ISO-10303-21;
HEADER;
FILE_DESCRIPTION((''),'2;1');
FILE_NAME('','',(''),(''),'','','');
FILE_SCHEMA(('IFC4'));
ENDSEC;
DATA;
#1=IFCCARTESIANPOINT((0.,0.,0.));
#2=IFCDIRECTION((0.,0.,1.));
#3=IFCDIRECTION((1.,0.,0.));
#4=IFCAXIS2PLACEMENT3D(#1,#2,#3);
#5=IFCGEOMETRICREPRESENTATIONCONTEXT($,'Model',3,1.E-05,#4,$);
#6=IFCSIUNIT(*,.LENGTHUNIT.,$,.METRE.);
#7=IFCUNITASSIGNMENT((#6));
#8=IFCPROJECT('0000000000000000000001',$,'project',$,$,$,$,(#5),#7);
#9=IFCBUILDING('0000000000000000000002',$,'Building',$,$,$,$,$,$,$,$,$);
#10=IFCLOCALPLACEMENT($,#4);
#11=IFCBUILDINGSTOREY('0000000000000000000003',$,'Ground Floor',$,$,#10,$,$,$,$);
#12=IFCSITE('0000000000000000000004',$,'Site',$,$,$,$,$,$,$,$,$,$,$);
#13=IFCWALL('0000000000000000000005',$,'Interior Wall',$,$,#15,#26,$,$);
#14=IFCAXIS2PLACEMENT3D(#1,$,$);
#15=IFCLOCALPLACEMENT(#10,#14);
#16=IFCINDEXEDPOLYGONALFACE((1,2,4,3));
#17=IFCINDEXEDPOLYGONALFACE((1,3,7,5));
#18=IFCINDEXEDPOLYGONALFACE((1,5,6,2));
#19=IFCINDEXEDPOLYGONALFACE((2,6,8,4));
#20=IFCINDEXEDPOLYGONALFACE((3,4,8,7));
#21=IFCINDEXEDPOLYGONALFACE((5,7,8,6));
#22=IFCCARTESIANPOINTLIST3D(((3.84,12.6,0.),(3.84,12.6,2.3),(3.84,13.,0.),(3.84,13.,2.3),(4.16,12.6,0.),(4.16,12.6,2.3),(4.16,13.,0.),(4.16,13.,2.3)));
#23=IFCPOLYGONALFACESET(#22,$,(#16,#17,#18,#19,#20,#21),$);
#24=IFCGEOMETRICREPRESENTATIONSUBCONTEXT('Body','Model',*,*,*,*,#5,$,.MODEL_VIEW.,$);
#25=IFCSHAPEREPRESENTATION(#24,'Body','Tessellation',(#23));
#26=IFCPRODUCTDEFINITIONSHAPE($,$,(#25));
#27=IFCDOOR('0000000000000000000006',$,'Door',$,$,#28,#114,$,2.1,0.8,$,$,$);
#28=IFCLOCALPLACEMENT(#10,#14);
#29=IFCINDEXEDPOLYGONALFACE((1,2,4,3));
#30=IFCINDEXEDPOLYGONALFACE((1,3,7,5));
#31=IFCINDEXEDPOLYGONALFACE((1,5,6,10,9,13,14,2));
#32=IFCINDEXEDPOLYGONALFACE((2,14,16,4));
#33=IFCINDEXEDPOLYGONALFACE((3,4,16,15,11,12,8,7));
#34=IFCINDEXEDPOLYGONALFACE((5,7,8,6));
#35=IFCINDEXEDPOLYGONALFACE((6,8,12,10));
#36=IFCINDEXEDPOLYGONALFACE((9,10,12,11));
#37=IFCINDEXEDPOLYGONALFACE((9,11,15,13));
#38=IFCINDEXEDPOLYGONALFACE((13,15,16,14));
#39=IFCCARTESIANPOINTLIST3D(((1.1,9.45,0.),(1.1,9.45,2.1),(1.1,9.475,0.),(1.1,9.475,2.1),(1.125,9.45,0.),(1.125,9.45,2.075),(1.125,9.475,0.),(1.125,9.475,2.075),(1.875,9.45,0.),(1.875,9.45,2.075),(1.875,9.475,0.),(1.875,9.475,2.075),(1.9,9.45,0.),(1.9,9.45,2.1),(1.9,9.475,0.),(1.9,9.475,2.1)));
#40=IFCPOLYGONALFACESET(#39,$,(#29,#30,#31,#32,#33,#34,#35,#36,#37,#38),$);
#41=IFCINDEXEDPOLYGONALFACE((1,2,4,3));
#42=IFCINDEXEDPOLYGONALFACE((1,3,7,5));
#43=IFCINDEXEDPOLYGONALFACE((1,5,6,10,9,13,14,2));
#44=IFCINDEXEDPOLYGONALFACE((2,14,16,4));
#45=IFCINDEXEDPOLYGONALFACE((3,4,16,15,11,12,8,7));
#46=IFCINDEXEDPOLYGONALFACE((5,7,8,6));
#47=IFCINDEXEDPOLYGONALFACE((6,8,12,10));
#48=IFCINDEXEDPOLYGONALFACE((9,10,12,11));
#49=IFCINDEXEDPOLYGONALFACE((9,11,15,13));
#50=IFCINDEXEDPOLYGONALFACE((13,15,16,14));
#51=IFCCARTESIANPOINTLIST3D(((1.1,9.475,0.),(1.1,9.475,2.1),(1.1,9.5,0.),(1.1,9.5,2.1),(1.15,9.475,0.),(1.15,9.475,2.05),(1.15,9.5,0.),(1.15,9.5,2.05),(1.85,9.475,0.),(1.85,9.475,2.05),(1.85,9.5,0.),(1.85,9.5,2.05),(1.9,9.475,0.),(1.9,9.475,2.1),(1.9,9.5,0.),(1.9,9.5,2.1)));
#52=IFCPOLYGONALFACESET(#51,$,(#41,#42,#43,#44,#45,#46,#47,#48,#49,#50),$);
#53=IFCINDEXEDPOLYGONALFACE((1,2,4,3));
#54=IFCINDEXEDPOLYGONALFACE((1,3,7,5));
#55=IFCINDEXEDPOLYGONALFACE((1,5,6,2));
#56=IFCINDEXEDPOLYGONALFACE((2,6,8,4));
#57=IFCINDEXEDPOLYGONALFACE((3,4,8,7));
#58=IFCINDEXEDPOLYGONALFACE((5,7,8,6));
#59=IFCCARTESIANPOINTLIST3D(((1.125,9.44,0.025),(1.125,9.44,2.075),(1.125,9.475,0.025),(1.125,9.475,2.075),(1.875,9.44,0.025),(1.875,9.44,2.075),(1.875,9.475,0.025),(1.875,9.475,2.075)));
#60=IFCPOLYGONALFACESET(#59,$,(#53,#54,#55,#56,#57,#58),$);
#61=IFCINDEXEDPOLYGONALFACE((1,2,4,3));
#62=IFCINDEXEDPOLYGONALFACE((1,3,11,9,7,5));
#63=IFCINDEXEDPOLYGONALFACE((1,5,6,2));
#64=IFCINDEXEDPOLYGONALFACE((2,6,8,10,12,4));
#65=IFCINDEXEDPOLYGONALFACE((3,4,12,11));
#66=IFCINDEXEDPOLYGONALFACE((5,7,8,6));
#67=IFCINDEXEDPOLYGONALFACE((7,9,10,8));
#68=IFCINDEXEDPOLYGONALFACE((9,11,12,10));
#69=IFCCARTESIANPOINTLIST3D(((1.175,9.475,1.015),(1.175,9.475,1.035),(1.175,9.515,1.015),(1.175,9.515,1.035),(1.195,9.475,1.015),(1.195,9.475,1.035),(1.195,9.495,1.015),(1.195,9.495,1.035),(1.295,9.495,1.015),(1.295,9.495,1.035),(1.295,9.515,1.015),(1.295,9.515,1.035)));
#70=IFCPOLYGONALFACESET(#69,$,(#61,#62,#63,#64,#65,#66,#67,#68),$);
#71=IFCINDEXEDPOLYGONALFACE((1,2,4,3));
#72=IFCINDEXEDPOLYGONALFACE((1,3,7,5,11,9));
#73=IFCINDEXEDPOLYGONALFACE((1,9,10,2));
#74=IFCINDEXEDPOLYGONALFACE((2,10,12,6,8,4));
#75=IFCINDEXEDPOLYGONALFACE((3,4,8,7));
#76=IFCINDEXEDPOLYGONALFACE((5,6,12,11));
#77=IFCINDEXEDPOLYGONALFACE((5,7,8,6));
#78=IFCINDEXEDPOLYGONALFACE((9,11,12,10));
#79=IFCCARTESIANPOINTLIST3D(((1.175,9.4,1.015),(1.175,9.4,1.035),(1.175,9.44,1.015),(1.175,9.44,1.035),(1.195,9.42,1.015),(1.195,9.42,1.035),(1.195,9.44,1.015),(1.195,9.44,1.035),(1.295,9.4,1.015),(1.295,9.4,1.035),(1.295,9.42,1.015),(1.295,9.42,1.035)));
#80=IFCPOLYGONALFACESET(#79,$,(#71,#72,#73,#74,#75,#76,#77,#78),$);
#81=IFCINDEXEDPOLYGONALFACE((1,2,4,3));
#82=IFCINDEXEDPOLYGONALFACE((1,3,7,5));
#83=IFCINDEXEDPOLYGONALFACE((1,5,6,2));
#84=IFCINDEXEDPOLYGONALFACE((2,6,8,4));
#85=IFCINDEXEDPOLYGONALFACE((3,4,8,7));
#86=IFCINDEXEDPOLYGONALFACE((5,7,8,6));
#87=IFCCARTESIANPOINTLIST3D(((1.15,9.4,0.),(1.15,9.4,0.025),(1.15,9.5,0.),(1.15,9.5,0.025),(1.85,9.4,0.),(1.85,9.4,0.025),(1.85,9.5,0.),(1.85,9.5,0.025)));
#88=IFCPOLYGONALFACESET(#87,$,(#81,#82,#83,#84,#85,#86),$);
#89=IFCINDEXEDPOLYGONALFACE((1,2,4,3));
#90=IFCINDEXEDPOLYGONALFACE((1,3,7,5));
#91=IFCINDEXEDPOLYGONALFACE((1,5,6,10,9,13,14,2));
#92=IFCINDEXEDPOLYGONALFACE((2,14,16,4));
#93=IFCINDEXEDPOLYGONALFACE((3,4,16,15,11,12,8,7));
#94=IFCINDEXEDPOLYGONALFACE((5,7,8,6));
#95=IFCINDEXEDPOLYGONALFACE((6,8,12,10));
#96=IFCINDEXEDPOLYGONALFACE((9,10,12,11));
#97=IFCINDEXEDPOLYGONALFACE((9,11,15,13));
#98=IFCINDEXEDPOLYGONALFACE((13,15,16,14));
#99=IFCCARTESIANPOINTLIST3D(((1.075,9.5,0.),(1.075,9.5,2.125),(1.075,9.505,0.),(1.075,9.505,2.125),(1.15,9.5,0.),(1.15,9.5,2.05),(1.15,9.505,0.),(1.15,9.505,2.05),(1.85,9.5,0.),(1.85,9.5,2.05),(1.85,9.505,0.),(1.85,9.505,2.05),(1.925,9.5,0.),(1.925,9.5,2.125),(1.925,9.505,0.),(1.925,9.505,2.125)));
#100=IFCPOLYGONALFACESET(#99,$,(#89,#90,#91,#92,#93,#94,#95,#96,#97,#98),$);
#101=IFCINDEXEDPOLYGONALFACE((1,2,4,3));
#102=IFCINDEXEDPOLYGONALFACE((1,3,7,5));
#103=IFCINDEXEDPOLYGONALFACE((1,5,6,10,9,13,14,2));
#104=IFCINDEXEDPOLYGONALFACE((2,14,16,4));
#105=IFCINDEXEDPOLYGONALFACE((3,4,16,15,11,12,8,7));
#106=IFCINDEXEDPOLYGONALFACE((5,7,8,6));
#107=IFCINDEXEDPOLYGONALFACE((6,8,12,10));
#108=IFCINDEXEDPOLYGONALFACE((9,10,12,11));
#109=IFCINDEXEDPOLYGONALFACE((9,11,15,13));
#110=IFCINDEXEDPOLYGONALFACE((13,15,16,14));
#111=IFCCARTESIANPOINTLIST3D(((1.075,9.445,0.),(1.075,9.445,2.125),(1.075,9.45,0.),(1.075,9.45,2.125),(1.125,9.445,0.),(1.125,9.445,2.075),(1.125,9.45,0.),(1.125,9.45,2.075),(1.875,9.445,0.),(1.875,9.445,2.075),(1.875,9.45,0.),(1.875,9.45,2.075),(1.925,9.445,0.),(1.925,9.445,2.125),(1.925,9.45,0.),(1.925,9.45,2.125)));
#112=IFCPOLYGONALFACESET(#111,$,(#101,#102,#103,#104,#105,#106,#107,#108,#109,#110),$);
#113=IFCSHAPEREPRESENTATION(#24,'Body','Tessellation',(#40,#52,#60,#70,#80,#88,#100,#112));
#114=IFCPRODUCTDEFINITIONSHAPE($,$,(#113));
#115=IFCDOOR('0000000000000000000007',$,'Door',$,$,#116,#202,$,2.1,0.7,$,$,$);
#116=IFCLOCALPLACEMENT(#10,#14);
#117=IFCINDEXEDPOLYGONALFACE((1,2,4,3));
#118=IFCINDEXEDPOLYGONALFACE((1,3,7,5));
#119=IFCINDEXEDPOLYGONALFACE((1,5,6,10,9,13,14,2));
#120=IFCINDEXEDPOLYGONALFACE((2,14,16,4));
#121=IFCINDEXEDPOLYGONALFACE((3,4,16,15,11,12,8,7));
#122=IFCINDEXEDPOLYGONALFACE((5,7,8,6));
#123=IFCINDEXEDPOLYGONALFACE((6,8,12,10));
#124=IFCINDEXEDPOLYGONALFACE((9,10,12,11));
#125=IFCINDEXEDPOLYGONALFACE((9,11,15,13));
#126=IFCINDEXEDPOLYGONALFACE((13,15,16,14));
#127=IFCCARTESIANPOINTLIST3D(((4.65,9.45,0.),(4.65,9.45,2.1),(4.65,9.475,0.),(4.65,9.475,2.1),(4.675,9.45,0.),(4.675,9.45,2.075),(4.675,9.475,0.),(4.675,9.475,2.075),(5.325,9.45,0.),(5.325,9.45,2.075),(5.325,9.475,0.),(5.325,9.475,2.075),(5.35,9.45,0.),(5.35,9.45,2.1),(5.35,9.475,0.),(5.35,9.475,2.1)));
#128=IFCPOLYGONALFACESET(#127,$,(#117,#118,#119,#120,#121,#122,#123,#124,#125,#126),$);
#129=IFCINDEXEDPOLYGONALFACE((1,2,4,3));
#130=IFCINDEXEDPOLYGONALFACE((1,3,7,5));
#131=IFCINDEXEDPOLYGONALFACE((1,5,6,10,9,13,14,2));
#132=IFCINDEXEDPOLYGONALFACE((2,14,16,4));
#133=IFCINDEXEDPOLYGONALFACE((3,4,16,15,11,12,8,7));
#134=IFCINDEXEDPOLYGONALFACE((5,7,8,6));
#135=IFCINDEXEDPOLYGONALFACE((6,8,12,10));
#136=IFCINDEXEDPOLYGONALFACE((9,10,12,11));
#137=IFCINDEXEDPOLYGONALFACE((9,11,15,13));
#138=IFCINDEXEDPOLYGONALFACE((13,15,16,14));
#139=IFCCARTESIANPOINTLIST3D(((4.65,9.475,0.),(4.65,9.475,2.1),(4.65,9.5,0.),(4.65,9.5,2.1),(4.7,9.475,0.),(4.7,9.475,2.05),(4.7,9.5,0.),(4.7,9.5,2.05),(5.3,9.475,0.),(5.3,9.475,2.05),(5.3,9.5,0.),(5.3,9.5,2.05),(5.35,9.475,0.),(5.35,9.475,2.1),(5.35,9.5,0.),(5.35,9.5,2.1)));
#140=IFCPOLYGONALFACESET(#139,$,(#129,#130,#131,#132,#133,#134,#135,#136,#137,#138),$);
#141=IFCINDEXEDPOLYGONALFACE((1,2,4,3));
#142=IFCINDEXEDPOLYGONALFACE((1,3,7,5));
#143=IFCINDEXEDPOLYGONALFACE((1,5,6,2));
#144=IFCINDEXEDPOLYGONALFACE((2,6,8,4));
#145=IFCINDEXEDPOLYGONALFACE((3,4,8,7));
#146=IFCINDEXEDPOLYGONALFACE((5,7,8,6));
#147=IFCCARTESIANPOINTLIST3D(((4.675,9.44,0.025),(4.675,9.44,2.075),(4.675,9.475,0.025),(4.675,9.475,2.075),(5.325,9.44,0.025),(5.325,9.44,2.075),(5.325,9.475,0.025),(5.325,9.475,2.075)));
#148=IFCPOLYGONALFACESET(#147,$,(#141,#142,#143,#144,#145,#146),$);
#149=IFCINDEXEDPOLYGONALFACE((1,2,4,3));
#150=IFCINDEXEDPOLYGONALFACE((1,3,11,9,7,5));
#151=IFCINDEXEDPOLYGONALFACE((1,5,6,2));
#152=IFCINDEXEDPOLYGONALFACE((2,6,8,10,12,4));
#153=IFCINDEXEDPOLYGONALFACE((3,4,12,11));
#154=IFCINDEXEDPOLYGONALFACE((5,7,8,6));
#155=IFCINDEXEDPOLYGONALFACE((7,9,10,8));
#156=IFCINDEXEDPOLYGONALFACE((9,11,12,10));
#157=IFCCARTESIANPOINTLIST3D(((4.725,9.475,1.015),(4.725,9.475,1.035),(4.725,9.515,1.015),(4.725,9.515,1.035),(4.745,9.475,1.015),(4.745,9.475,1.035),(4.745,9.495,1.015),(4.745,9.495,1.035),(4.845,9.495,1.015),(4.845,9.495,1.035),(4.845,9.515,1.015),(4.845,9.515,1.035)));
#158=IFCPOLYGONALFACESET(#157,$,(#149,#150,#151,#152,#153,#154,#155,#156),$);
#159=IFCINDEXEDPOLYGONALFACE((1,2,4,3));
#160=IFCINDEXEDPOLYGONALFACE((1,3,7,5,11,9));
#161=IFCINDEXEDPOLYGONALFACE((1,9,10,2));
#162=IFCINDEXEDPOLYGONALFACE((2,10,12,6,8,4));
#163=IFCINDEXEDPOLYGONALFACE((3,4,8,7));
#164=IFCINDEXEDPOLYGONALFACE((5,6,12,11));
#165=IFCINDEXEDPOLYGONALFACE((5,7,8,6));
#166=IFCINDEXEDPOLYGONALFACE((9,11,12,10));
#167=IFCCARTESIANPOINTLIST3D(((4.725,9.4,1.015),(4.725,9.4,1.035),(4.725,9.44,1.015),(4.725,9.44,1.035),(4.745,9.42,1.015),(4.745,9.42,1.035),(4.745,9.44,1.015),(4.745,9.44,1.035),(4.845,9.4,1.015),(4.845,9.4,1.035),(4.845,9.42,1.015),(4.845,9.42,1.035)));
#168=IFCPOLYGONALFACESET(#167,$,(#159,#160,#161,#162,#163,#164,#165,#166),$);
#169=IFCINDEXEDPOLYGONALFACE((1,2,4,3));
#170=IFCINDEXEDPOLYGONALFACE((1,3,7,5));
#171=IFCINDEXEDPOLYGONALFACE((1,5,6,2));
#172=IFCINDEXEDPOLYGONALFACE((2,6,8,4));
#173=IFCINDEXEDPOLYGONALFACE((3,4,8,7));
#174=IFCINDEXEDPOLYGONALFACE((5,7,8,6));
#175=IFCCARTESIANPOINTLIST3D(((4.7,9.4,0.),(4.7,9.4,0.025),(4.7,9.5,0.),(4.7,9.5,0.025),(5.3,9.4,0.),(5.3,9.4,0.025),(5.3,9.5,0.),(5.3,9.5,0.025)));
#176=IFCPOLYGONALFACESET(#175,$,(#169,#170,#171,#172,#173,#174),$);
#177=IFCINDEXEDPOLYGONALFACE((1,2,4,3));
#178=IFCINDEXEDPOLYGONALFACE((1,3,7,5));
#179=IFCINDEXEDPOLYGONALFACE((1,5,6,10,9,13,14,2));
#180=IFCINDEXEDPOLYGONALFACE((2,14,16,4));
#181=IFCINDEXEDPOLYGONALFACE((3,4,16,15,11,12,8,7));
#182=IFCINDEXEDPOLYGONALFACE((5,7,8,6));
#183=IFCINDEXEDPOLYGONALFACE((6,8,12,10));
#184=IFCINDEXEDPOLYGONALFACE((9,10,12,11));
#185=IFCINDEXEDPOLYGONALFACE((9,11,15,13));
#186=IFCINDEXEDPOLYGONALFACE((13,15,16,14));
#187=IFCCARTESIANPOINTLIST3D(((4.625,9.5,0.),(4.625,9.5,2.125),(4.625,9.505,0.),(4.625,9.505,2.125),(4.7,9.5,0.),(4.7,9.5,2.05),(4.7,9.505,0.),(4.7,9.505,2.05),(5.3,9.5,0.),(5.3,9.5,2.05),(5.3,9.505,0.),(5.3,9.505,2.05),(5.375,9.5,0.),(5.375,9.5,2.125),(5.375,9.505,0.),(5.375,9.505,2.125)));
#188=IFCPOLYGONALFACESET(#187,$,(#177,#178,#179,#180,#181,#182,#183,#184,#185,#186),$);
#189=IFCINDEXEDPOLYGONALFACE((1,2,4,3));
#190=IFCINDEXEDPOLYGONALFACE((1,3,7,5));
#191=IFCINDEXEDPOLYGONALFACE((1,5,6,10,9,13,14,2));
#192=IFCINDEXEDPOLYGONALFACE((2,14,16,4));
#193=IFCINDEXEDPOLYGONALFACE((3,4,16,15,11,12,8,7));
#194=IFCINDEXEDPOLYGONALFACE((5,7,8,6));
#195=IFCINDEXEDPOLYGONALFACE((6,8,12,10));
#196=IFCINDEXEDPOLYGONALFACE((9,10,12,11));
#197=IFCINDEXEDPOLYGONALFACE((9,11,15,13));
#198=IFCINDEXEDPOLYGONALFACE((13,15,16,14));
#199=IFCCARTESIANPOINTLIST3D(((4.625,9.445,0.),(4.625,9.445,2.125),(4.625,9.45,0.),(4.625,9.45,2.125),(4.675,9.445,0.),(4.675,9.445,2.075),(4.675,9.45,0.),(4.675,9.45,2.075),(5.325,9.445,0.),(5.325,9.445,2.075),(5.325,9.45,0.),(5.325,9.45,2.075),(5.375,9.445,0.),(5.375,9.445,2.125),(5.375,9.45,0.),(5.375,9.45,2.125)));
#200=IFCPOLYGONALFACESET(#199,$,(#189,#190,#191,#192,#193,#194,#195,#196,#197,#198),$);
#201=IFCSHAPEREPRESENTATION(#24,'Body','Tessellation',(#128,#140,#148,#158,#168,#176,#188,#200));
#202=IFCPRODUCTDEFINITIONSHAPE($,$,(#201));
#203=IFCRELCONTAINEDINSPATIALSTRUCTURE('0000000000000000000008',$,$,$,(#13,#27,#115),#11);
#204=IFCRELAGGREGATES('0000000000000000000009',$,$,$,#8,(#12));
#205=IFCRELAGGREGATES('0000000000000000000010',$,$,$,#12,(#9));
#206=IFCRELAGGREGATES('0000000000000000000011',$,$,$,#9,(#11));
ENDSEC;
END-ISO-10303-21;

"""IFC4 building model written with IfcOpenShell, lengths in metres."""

from ifc_helpers import new_model, si_unit, frame, origin_with_axes, place, context, subcontext, project, spatial, line, indexed_curve, outline, extrude, element, save


model = new_model("IFC4")

# Units and contexts
model_context = context("Model", 3, precision=1e-05, world=origin_with_axes())
body_context = subcontext(model_context, "Body", "Model", "MODEL_VIEW")
ifc_project = project(units=[si_unit("LENGTHUNIT", "METRE")], contexts=[model_context])

# Site, building, storey
site = spatial("IfcSite", under=ifc_project, Name="Site")
building = spatial("IfcBuilding", under=site, Name="Building")
storey_placement = place(None, origin_with_axes())
storey = spatial("IfcBuildingStorey", under=building, at=storey_placement, Name="Ground Floor")

# Wall
for number, where, z_axis, x_axis, name in (
    (1, (4.0, 12.6, 0.0), (0.0, 0.0, 1.0), (0.0, 1.0, 0.0), "Interior Wall"),
):
    element("IfcWall", number, at=place(storey_placement, frame(where, z_axis=z_axis, x_axis=x_axis)), inside=storey, Name=name, context=body_context, shape_type="SweptSolid", body=[
        extrude(outline(indexed_curve([(0.0, 0.0), (0.0, 0.32), (0.4, 0.32), (0.4, 0.0), (0.0, 0.0)], self_intersect=False)), frame((0.0, -0.16, 0.0), z_axis=(0.0, 0.0, 1.0), x_axis=(1.0, 0.0, 0.0)), (0.0, 0.0, 1.0), 2.3),
    ])

# Doors
door_1_placement = place(storey_placement, frame((1.9, 9.5, 0.0), z_axis=(0.0, 0.0, 1.0), x_axis=(-1.0, 0.0, 0.0)))
element("IfcDoor", 2, at=door_1_placement, inside=storey, Name="Door", OverallHeight=2.1, OverallWidth=0.8, context=body_context, shape_type="SweptSolid", body=[
    extrude(outline(indexed_curve([(0.0, 0.0), (0.0, 2.1), (0.8, 2.1), (0.8, 0.0), (0.775, 0.0), (0.775, 2.075), (0.025, 2.075), (0.025, 0.0)], segments=[line(1, 2, 3, 4, 5, 6, 7, 8, 1)])), frame((0.0, 0.025, 0.0), z_axis=(0.0, -1.0, 0.0), x_axis=(1.0, 0.0, 0.0)), (0.0, 0.0, -1.0), 0.025),
    extrude(outline(indexed_curve([(0.0, 0.0), (0.0, 2.1), (0.8, 2.1), (0.8, 0.0), (0.75, 0.0), (0.75, 2.05), (0.05, 2.05), (0.05, 0.0)], segments=[line(1, 2, 3, 4, 5, 6, 7, 8, 1)])), frame((0.0, 0.0, 0.0), z_axis=(0.0, -1.0, 0.0), x_axis=(1.0, 0.0, 0.0)), (0.0, 0.0, -1.0), 0.025),
    extrude(outline(indexed_curve([(0.0, 0.0), (0.75, 0.0), (0.75, 0.035), (0.0, 0.035)], segments=[line(1, 2, 3, 4, 1)])), frame((0.025, 0.025, 0.025), z_axis=(0.0, 0.0, 1.0), x_axis=(1.0, 0.0, 0.0)), (0.0, 0.0, 1.0), 2.05),
    extrude(outline(indexed_curve([(0.0, 0.0), (0.0, -0.04), (-0.12, -0.04), (-0.12, -0.02), (-0.02, -0.02), (-0.02, 0.0)], segments=[line(1, 2, 3, 4, 5, 6, 1)])), frame((0.725, 0.025, 1.015), z_axis=(0.0, 0.0, 1.0), x_axis=(1.0, 0.0, 0.0)), (0.0, 0.0, 1.0), 0.02),
    extrude(outline(indexed_curve([(0.0, 0.0), (0.0, 0.04), (-0.12, 0.04), (-0.12, 0.02), (-0.02, 0.02), (-0.02, 0.0)], segments=[line(1, 2, 3, 4, 5, 6, 1)])), frame((0.725, 0.06, 1.015), z_axis=(0.0, 0.0, 1.0), x_axis=(1.0, 0.0, 0.0)), (0.0, 0.0, 1.0), 0.02),
    extrude(outline(indexed_curve([(0.0, 0.0), (0.7, 0.0), (0.7, 0.1), (0.0, 0.1)], segments=[line(1, 2, 3, 4, 1)])), frame((0.05, 0.0, 0.0), z_axis=(0.0, 0.0, 1.0), x_axis=(1.0, 0.0, 0.0)), (0.0, 0.0, 1.0), 0.025),
    extrude(outline(indexed_curve([(0.0, 0.0), (0.0, 2.125), (0.85, 2.125), (0.85, 0.0), (0.775, 0.0), (0.775, 2.05), (0.075, 2.05), (0.075, 0.0)], segments=[line(1, 2, 3, 4, 5, 6, 7, 8, 1)])), frame((-0.025, -0.005, 0.0), z_axis=(0.0, -1.0, 0.0), x_axis=(1.0, 0.0, 0.0)), (0.0, 0.0, -1.0), 0.005),
    extrude(outline(indexed_curve([(0.0, 0.0), (0.0, 2.125), (0.85, 2.125), (0.85, 0.0), (0.8, 0.0), (0.8, 2.075), (0.05, 2.075), (0.05, 0.0)], segments=[line(1, 2, 3, 4, 5, 6, 7, 8, 1)])), frame((-0.025, 0.05, 0.0), z_axis=(0.0, -1.0, 0.0), x_axis=(1.0, 0.0, 0.0)), (0.0, 0.0, -1.0), 0.005),
])
door_2_placement = place(storey_placement, frame((5.35, 9.5, 0.0), z_axis=(0.0, 0.0, 1.0), x_axis=(-1.0, 0.0, 0.0)))
element("IfcDoor", 3, at=door_2_placement, inside=storey, Name="Door", OverallHeight=2.1, OverallWidth=0.7, context=body_context, shape_type="SweptSolid", body=[
    extrude(outline(indexed_curve([(0.0, 0.0), (0.0, 2.1), (0.7, 2.1), (0.7, 0.0), (0.675, 0.0), (0.675, 2.075), (0.025, 2.075), (0.025, 0.0)], segments=[line(1, 2, 3, 4, 5, 6, 7, 8, 1)])), frame((0.0, 0.025, 0.0), z_axis=(0.0, -1.0, 0.0), x_axis=(1.0, 0.0, 0.0)), (0.0, 0.0, -1.0), 0.025),
    extrude(outline(indexed_curve([(0.0, 0.0), (0.0, 2.1), (0.7, 2.1), (0.7, 0.0), (0.65, 0.0), (0.65, 2.05), (0.05, 2.05), (0.05, 0.0)], segments=[line(1, 2, 3, 4, 5, 6, 7, 8, 1)])), frame((0.0, 0.0, 0.0), z_axis=(0.0, -1.0, 0.0), x_axis=(1.0, 0.0, 0.0)), (0.0, 0.0, -1.0), 0.025),
    extrude(outline(indexed_curve([(0.0, 0.0), (0.65, 0.0), (0.65, 0.035), (0.0, 0.035)], segments=[line(1, 2, 3, 4, 1)])), frame((0.025, 0.025, 0.025), z_axis=(0.0, 0.0, 1.0), x_axis=(1.0, 0.0, 0.0)), (0.0, 0.0, 1.0), 2.05),
    extrude(outline(indexed_curve([(0.0, 0.0), (0.0, -0.04), (-0.12, -0.04), (-0.12, -0.02), (-0.02, -0.02), (-0.02, 0.0)], segments=[line(1, 2, 3, 4, 5, 6, 1)])), frame((0.625, 0.025, 1.015), z_axis=(0.0, 0.0, 1.0), x_axis=(1.0, 0.0, 0.0)), (0.0, 0.0, 1.0), 0.02),
    extrude(outline(indexed_curve([(0.0, 0.0), (0.0, 0.04), (-0.12, 0.04), (-0.12, 0.02), (-0.02, 0.02), (-0.02, 0.0)], segments=[line(1, 2, 3, 4, 5, 6, 1)])), frame((0.625, 0.06, 1.015), z_axis=(0.0, 0.0, 1.0), x_axis=(1.0, 0.0, 0.0)), (0.0, 0.0, 1.0), 0.02),
    extrude(outline(indexed_curve([(0.0, 0.0), (0.6, 0.0), (0.6, 0.1), (0.0, 0.1)], segments=[line(1, 2, 3, 4, 1)])), frame((0.05, 0.0, 0.0), z_axis=(0.0, 0.0, 1.0), x_axis=(1.0, 0.0, 0.0)), (0.0, 0.0, 1.0), 0.025),
    extrude(outline(indexed_curve([(0.0, 0.0), (0.0, 2.125), (0.75, 2.125), (0.75, 0.0), (0.675, 0.0), (0.675, 2.05), (0.075, 2.05), (0.075, 0.0)], segments=[line(1, 2, 3, 4, 5, 6, 7, 8, 1)])), frame((-0.025, -0.005, 0.0), z_axis=(0.0, -1.0, 0.0), x_axis=(1.0, 0.0, 0.0)), (0.0, 0.0, -1.0), 0.005),
    extrude(outline(indexed_curve([(0.0, 0.0), (0.0, 2.125), (0.75, 2.125), (0.75, 0.0), (0.7, 0.0), (0.7, 2.075), (0.05, 2.075), (0.05, 0.0)], segments=[line(1, 2, 3, 4, 5, 6, 7, 8, 1)])), frame((-0.025, 0.05, 0.0), z_axis=(0.0, -1.0, 0.0), x_axis=(1.0, 0.0, 0.0)), (0.0, 0.0, -1.0), 0.005),
])

save(model, "model.ifc")
